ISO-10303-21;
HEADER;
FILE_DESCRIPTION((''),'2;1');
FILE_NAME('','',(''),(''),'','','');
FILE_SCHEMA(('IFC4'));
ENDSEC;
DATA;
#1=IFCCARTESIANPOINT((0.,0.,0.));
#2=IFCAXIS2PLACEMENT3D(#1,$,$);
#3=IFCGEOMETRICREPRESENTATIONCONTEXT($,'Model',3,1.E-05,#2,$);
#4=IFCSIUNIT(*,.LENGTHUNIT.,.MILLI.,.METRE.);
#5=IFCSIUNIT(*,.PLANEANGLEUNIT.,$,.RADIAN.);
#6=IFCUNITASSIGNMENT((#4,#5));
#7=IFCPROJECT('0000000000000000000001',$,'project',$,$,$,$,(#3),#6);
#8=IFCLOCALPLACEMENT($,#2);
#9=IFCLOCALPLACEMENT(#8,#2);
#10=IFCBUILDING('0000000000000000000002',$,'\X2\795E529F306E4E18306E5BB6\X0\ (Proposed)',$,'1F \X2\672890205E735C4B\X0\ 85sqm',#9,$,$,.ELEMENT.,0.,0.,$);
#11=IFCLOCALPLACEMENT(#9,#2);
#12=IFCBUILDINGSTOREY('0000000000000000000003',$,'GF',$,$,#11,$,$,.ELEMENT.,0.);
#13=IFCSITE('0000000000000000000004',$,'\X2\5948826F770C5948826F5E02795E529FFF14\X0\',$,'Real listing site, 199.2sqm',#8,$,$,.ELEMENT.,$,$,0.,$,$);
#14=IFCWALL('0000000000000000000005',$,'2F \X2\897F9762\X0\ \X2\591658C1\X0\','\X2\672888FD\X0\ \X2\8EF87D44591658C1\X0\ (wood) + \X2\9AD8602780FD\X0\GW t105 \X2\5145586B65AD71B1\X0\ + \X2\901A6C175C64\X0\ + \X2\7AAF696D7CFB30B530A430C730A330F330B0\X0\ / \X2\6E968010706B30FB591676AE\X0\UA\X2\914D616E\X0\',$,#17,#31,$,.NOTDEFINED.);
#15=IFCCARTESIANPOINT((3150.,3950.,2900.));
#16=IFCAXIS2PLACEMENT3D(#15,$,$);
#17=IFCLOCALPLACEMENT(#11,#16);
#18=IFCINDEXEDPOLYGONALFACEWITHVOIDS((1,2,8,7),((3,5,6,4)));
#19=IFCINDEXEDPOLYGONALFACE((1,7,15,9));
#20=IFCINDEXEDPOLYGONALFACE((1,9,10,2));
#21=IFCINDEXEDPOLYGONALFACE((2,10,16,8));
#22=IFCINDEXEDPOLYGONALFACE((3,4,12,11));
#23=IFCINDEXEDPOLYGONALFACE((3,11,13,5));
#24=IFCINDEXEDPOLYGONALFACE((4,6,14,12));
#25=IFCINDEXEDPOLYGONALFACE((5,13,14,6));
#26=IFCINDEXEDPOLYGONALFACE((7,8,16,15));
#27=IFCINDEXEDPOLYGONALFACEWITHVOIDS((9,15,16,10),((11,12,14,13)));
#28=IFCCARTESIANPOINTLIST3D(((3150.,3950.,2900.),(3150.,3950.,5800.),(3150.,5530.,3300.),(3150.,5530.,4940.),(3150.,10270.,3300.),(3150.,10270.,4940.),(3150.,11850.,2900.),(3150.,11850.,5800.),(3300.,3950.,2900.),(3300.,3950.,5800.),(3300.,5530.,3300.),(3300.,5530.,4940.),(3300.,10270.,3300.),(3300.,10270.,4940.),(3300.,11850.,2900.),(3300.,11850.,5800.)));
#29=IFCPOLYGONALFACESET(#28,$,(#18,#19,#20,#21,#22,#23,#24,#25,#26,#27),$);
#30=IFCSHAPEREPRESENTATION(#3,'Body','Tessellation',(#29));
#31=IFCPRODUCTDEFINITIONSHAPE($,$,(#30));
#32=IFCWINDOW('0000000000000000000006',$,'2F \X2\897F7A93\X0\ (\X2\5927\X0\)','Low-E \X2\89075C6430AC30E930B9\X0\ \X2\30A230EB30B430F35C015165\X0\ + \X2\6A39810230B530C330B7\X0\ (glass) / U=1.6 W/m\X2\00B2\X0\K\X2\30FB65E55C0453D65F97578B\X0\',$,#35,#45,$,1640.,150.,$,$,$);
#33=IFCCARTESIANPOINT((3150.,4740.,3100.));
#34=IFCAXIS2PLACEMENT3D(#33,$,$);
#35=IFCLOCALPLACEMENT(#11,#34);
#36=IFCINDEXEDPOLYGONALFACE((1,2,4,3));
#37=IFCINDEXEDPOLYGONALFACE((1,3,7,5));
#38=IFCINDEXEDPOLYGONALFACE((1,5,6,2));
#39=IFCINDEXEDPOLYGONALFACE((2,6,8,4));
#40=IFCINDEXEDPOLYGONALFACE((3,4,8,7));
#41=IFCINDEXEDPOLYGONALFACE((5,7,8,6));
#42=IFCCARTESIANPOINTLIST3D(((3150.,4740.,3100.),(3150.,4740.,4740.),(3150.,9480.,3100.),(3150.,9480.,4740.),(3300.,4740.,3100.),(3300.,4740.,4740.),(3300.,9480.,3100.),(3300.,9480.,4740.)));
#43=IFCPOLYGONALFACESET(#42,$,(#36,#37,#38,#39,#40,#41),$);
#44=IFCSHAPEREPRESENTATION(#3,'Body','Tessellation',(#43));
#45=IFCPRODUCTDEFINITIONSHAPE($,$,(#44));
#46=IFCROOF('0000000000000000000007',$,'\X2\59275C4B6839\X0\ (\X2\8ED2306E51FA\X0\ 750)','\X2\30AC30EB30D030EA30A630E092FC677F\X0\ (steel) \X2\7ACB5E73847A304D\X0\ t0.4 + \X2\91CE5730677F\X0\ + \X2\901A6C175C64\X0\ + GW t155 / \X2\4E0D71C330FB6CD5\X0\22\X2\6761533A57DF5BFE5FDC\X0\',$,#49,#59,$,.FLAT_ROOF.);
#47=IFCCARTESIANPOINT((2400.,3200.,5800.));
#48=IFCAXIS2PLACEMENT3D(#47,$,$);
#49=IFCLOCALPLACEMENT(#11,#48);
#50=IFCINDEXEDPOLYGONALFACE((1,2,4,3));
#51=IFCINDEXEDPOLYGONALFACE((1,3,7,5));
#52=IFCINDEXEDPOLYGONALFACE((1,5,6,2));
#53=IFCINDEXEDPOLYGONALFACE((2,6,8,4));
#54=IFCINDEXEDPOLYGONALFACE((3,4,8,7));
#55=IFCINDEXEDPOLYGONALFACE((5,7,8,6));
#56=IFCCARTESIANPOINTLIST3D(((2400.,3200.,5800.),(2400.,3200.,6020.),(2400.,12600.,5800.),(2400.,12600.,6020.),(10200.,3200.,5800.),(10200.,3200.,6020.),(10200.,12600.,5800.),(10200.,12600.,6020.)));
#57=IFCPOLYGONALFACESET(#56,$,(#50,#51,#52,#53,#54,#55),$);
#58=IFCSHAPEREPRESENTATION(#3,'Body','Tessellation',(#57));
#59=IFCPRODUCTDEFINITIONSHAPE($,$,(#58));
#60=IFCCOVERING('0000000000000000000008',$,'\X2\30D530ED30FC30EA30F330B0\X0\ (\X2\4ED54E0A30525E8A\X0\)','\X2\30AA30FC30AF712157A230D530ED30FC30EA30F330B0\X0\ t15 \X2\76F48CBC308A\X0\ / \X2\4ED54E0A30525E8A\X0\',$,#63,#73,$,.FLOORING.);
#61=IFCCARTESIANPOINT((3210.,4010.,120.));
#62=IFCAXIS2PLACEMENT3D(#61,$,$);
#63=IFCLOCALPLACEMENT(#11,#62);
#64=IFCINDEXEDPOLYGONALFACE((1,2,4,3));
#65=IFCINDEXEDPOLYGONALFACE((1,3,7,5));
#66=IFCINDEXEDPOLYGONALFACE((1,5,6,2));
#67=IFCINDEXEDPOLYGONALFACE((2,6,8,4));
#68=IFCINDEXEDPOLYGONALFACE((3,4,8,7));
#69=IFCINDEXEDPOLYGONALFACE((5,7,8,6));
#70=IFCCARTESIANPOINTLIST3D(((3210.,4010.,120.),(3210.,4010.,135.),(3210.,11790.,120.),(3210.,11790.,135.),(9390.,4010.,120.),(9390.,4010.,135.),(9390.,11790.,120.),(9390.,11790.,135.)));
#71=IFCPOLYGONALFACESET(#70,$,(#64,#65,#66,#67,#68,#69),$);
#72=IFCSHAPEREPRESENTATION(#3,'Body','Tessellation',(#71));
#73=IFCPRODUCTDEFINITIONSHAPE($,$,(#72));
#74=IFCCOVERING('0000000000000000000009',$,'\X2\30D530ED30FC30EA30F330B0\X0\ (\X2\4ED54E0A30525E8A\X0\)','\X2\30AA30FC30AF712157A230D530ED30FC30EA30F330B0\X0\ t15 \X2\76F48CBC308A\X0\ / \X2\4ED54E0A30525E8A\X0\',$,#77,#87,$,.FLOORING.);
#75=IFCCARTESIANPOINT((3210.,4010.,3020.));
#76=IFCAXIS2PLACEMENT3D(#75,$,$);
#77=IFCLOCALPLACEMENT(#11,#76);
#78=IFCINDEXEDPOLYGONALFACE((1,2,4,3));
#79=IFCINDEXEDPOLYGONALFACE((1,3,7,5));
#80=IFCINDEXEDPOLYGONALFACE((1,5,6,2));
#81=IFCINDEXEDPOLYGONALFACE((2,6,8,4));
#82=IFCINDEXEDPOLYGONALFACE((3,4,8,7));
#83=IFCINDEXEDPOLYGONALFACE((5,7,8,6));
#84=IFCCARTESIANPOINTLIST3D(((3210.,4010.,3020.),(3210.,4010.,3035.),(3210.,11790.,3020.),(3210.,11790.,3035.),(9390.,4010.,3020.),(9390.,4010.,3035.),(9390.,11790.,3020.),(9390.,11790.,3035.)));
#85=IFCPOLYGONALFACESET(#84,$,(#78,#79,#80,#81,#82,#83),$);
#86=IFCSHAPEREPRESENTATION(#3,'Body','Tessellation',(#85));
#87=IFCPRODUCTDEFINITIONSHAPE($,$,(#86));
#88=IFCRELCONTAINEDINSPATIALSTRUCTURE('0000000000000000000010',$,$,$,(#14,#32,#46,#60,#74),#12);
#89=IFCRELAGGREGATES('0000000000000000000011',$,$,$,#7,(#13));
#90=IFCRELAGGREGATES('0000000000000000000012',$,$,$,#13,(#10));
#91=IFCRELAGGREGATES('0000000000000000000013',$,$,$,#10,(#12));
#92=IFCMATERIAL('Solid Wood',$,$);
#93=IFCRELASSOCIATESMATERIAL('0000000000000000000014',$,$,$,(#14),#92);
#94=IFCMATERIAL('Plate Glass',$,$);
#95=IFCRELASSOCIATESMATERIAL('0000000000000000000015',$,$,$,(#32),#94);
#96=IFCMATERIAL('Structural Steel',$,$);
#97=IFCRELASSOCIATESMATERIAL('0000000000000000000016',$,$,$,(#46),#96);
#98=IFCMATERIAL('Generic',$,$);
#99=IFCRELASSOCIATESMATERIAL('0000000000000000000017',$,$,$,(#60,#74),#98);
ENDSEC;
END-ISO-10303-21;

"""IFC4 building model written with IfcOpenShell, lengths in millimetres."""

from ifc_helpers import new_model, si_unit, frame, frame_2d, origin, place, context, project, spatial, rectangle, extrude, material, element, fill, save


model = new_model("IFC4")

# Units and contexts
model_context = context("Model", 3, precision=1e-05, world=origin())
ifc_project = project(units=[si_unit("LENGTHUNIT", "METRE", prefix="MILLI"), si_unit("PLANEANGLEUNIT", "RADIAN")], contexts=[model_context])

# Site, building, storey
site_placement = place(None, origin())
site = spatial("IfcSite", under=ifc_project, at=site_placement, Name="奈良県奈良市神功４", ObjectType="Real listing site, 199.2sqm", CompositionType="ELEMENT", RefElevation=0.0)
building_placement = place(site_placement, origin())
building = spatial("IfcBuilding", under=site, at=building_placement, Name="神功の丘の家 (Proposed)", ObjectType="1F 木造平屋 85sqm", CompositionType="ELEMENT", ElevationOfRefHeight=0.0, ElevationOfTerrain=0.0)
storey_placement = place(building_placement, origin())
storey = spatial("IfcBuildingStorey", under=building, at=storey_placement, Name="GF", CompositionType="ELEMENT", Elevation=0.0)

# Shared definitions
ifc_material_1 = material(Name="Solid Wood")
ifc_material_2 = material(Name="Generic")

# Shared definitions
ifc_material_3 = material(Name="Plate Glass")

# Wall, opening, window
wall_1_placement = place(storey_placement, frame((3150.0, 3950.0, 2900.0)))
wall_1 = element("IfcWall", 1, at=wall_1_placement, inside=storey, material=ifc_material_1, Name="2F 西面 外壁", Description="木製 軸組外壁 (wood) + 高性能GW t105 充填断熱 + 通気層 + 窯業系サイディング / 準耐火・外皮UA配慮", PredefinedType="NOTDEFINED", context=model_context, shape_type="SweptSolid", body=[
    extrude(rectangle(XDim=150.0, YDim=7900.0, at=frame_2d((75.0, 3950.0))), frame((3150.0, 3950.0, 2900.0)), (0.0, 0.0, 1.0), 2900.0),
])
opening_1_placement = place(storey_placement, frame((3150.0, 4740.0, 3100.0)))
opening_1 = element("IfcOpeningElement", 2, at=opening_1_placement, cuts=wall_1, PredefinedType="NOTDEFINED", context=model_context, shape_type="SweptSolid", body=[
    extrude(rectangle(XDim=150.0, YDim=4740.0, at=frame_2d((75.0, 2370.0))), frame((3150.0, 4740.0, 3100.0)), (0.0, 0.0, 1.0), 1640.0),
])
window_1_placement = place(storey_placement, frame((3150.0, 4740.0, 3100.0)))
window_1 = element("IfcWindow", 3, at=window_1_placement, inside=storey, material=ifc_material_3, Name="2F 西窓 (大)", Description="Low-E 複層ガラス アルゴン封入 + 樹脂サッシ (glass) / U=1.6 W/m²K・日射取得型", OverallHeight=1640.0, OverallWidth=150.0, context=model_context, shape_type="SweptSolid", body=[
    extrude(rectangle(XDim=150.0, YDim=4740.0, at=frame_2d((75.0, 2370.0))), frame((3150.0, 4740.0, 3100.0)), (0.0, 0.0, 1.0), 1640.0),
])
fill(opening_1, window_1)

# Roof
ifc_material_4 = material(Name="Structural Steel")
roof_placement = place(storey_placement, frame((2400.0, 3200.0, 5800.0)))
element("IfcRoof", 4, at=roof_placement, inside=storey, material=ifc_material_4, Name="大屋根 (軒の出 750)", Description="ガルバリウム鋼板 (steel) 立平葺き t0.4 + 野地板 + 通気層 + GW t155 / 不燃・法22条区域対応", PredefinedType="FLAT_ROOF", context=model_context, shape_type="SweptSolid", body=[
    extrude(rectangle(XDim=7800.0, YDim=9400.0, at=frame_2d((3900.0, 4700.0))), frame((2400.0, 3200.0, 5800.0)), (0.0, 0.0, 1.0), 220.0),
])

# Coverings
covering_1_placement = place(storey_placement, frame((3210.0, 4010.0, 120.0)))
element("IfcCovering", 5, at=covering_1_placement, inside=storey, material=ifc_material_2, Name="フローリング (仕上げ床)", Description="オーク無垢フローリング t15 直貼り / 仕上げ床", PredefinedType="FLOORING", context=model_context, shape_type="SweptSolid", body=[
    extrude(rectangle(XDim=6180.0, YDim=7780.0, at=frame_2d((3090.0, 3890.0))), frame((3210.0, 4010.0, 120.0)), (0.0, 0.0, 1.0), 15.0),
])
covering_2_placement = place(storey_placement, frame((3210.0, 4010.0, 3020.0)))
element("IfcCovering", 6, at=covering_2_placement, inside=storey, material=ifc_material_2, Name="フローリング (仕上げ床)", Description="オーク無垢フローリング t15 直貼り / 仕上げ床", PredefinedType="FLOORING", context=model_context, shape_type="SweptSolid", body=[
    extrude(rectangle(XDim=6180.0, YDim=7780.0, at=frame_2d((3090.0, 3890.0))), frame((3210.0, 4010.0, 3020.0)), (0.0, 0.0, 1.0), 15.0),
])

save(model, "model.ifc")
